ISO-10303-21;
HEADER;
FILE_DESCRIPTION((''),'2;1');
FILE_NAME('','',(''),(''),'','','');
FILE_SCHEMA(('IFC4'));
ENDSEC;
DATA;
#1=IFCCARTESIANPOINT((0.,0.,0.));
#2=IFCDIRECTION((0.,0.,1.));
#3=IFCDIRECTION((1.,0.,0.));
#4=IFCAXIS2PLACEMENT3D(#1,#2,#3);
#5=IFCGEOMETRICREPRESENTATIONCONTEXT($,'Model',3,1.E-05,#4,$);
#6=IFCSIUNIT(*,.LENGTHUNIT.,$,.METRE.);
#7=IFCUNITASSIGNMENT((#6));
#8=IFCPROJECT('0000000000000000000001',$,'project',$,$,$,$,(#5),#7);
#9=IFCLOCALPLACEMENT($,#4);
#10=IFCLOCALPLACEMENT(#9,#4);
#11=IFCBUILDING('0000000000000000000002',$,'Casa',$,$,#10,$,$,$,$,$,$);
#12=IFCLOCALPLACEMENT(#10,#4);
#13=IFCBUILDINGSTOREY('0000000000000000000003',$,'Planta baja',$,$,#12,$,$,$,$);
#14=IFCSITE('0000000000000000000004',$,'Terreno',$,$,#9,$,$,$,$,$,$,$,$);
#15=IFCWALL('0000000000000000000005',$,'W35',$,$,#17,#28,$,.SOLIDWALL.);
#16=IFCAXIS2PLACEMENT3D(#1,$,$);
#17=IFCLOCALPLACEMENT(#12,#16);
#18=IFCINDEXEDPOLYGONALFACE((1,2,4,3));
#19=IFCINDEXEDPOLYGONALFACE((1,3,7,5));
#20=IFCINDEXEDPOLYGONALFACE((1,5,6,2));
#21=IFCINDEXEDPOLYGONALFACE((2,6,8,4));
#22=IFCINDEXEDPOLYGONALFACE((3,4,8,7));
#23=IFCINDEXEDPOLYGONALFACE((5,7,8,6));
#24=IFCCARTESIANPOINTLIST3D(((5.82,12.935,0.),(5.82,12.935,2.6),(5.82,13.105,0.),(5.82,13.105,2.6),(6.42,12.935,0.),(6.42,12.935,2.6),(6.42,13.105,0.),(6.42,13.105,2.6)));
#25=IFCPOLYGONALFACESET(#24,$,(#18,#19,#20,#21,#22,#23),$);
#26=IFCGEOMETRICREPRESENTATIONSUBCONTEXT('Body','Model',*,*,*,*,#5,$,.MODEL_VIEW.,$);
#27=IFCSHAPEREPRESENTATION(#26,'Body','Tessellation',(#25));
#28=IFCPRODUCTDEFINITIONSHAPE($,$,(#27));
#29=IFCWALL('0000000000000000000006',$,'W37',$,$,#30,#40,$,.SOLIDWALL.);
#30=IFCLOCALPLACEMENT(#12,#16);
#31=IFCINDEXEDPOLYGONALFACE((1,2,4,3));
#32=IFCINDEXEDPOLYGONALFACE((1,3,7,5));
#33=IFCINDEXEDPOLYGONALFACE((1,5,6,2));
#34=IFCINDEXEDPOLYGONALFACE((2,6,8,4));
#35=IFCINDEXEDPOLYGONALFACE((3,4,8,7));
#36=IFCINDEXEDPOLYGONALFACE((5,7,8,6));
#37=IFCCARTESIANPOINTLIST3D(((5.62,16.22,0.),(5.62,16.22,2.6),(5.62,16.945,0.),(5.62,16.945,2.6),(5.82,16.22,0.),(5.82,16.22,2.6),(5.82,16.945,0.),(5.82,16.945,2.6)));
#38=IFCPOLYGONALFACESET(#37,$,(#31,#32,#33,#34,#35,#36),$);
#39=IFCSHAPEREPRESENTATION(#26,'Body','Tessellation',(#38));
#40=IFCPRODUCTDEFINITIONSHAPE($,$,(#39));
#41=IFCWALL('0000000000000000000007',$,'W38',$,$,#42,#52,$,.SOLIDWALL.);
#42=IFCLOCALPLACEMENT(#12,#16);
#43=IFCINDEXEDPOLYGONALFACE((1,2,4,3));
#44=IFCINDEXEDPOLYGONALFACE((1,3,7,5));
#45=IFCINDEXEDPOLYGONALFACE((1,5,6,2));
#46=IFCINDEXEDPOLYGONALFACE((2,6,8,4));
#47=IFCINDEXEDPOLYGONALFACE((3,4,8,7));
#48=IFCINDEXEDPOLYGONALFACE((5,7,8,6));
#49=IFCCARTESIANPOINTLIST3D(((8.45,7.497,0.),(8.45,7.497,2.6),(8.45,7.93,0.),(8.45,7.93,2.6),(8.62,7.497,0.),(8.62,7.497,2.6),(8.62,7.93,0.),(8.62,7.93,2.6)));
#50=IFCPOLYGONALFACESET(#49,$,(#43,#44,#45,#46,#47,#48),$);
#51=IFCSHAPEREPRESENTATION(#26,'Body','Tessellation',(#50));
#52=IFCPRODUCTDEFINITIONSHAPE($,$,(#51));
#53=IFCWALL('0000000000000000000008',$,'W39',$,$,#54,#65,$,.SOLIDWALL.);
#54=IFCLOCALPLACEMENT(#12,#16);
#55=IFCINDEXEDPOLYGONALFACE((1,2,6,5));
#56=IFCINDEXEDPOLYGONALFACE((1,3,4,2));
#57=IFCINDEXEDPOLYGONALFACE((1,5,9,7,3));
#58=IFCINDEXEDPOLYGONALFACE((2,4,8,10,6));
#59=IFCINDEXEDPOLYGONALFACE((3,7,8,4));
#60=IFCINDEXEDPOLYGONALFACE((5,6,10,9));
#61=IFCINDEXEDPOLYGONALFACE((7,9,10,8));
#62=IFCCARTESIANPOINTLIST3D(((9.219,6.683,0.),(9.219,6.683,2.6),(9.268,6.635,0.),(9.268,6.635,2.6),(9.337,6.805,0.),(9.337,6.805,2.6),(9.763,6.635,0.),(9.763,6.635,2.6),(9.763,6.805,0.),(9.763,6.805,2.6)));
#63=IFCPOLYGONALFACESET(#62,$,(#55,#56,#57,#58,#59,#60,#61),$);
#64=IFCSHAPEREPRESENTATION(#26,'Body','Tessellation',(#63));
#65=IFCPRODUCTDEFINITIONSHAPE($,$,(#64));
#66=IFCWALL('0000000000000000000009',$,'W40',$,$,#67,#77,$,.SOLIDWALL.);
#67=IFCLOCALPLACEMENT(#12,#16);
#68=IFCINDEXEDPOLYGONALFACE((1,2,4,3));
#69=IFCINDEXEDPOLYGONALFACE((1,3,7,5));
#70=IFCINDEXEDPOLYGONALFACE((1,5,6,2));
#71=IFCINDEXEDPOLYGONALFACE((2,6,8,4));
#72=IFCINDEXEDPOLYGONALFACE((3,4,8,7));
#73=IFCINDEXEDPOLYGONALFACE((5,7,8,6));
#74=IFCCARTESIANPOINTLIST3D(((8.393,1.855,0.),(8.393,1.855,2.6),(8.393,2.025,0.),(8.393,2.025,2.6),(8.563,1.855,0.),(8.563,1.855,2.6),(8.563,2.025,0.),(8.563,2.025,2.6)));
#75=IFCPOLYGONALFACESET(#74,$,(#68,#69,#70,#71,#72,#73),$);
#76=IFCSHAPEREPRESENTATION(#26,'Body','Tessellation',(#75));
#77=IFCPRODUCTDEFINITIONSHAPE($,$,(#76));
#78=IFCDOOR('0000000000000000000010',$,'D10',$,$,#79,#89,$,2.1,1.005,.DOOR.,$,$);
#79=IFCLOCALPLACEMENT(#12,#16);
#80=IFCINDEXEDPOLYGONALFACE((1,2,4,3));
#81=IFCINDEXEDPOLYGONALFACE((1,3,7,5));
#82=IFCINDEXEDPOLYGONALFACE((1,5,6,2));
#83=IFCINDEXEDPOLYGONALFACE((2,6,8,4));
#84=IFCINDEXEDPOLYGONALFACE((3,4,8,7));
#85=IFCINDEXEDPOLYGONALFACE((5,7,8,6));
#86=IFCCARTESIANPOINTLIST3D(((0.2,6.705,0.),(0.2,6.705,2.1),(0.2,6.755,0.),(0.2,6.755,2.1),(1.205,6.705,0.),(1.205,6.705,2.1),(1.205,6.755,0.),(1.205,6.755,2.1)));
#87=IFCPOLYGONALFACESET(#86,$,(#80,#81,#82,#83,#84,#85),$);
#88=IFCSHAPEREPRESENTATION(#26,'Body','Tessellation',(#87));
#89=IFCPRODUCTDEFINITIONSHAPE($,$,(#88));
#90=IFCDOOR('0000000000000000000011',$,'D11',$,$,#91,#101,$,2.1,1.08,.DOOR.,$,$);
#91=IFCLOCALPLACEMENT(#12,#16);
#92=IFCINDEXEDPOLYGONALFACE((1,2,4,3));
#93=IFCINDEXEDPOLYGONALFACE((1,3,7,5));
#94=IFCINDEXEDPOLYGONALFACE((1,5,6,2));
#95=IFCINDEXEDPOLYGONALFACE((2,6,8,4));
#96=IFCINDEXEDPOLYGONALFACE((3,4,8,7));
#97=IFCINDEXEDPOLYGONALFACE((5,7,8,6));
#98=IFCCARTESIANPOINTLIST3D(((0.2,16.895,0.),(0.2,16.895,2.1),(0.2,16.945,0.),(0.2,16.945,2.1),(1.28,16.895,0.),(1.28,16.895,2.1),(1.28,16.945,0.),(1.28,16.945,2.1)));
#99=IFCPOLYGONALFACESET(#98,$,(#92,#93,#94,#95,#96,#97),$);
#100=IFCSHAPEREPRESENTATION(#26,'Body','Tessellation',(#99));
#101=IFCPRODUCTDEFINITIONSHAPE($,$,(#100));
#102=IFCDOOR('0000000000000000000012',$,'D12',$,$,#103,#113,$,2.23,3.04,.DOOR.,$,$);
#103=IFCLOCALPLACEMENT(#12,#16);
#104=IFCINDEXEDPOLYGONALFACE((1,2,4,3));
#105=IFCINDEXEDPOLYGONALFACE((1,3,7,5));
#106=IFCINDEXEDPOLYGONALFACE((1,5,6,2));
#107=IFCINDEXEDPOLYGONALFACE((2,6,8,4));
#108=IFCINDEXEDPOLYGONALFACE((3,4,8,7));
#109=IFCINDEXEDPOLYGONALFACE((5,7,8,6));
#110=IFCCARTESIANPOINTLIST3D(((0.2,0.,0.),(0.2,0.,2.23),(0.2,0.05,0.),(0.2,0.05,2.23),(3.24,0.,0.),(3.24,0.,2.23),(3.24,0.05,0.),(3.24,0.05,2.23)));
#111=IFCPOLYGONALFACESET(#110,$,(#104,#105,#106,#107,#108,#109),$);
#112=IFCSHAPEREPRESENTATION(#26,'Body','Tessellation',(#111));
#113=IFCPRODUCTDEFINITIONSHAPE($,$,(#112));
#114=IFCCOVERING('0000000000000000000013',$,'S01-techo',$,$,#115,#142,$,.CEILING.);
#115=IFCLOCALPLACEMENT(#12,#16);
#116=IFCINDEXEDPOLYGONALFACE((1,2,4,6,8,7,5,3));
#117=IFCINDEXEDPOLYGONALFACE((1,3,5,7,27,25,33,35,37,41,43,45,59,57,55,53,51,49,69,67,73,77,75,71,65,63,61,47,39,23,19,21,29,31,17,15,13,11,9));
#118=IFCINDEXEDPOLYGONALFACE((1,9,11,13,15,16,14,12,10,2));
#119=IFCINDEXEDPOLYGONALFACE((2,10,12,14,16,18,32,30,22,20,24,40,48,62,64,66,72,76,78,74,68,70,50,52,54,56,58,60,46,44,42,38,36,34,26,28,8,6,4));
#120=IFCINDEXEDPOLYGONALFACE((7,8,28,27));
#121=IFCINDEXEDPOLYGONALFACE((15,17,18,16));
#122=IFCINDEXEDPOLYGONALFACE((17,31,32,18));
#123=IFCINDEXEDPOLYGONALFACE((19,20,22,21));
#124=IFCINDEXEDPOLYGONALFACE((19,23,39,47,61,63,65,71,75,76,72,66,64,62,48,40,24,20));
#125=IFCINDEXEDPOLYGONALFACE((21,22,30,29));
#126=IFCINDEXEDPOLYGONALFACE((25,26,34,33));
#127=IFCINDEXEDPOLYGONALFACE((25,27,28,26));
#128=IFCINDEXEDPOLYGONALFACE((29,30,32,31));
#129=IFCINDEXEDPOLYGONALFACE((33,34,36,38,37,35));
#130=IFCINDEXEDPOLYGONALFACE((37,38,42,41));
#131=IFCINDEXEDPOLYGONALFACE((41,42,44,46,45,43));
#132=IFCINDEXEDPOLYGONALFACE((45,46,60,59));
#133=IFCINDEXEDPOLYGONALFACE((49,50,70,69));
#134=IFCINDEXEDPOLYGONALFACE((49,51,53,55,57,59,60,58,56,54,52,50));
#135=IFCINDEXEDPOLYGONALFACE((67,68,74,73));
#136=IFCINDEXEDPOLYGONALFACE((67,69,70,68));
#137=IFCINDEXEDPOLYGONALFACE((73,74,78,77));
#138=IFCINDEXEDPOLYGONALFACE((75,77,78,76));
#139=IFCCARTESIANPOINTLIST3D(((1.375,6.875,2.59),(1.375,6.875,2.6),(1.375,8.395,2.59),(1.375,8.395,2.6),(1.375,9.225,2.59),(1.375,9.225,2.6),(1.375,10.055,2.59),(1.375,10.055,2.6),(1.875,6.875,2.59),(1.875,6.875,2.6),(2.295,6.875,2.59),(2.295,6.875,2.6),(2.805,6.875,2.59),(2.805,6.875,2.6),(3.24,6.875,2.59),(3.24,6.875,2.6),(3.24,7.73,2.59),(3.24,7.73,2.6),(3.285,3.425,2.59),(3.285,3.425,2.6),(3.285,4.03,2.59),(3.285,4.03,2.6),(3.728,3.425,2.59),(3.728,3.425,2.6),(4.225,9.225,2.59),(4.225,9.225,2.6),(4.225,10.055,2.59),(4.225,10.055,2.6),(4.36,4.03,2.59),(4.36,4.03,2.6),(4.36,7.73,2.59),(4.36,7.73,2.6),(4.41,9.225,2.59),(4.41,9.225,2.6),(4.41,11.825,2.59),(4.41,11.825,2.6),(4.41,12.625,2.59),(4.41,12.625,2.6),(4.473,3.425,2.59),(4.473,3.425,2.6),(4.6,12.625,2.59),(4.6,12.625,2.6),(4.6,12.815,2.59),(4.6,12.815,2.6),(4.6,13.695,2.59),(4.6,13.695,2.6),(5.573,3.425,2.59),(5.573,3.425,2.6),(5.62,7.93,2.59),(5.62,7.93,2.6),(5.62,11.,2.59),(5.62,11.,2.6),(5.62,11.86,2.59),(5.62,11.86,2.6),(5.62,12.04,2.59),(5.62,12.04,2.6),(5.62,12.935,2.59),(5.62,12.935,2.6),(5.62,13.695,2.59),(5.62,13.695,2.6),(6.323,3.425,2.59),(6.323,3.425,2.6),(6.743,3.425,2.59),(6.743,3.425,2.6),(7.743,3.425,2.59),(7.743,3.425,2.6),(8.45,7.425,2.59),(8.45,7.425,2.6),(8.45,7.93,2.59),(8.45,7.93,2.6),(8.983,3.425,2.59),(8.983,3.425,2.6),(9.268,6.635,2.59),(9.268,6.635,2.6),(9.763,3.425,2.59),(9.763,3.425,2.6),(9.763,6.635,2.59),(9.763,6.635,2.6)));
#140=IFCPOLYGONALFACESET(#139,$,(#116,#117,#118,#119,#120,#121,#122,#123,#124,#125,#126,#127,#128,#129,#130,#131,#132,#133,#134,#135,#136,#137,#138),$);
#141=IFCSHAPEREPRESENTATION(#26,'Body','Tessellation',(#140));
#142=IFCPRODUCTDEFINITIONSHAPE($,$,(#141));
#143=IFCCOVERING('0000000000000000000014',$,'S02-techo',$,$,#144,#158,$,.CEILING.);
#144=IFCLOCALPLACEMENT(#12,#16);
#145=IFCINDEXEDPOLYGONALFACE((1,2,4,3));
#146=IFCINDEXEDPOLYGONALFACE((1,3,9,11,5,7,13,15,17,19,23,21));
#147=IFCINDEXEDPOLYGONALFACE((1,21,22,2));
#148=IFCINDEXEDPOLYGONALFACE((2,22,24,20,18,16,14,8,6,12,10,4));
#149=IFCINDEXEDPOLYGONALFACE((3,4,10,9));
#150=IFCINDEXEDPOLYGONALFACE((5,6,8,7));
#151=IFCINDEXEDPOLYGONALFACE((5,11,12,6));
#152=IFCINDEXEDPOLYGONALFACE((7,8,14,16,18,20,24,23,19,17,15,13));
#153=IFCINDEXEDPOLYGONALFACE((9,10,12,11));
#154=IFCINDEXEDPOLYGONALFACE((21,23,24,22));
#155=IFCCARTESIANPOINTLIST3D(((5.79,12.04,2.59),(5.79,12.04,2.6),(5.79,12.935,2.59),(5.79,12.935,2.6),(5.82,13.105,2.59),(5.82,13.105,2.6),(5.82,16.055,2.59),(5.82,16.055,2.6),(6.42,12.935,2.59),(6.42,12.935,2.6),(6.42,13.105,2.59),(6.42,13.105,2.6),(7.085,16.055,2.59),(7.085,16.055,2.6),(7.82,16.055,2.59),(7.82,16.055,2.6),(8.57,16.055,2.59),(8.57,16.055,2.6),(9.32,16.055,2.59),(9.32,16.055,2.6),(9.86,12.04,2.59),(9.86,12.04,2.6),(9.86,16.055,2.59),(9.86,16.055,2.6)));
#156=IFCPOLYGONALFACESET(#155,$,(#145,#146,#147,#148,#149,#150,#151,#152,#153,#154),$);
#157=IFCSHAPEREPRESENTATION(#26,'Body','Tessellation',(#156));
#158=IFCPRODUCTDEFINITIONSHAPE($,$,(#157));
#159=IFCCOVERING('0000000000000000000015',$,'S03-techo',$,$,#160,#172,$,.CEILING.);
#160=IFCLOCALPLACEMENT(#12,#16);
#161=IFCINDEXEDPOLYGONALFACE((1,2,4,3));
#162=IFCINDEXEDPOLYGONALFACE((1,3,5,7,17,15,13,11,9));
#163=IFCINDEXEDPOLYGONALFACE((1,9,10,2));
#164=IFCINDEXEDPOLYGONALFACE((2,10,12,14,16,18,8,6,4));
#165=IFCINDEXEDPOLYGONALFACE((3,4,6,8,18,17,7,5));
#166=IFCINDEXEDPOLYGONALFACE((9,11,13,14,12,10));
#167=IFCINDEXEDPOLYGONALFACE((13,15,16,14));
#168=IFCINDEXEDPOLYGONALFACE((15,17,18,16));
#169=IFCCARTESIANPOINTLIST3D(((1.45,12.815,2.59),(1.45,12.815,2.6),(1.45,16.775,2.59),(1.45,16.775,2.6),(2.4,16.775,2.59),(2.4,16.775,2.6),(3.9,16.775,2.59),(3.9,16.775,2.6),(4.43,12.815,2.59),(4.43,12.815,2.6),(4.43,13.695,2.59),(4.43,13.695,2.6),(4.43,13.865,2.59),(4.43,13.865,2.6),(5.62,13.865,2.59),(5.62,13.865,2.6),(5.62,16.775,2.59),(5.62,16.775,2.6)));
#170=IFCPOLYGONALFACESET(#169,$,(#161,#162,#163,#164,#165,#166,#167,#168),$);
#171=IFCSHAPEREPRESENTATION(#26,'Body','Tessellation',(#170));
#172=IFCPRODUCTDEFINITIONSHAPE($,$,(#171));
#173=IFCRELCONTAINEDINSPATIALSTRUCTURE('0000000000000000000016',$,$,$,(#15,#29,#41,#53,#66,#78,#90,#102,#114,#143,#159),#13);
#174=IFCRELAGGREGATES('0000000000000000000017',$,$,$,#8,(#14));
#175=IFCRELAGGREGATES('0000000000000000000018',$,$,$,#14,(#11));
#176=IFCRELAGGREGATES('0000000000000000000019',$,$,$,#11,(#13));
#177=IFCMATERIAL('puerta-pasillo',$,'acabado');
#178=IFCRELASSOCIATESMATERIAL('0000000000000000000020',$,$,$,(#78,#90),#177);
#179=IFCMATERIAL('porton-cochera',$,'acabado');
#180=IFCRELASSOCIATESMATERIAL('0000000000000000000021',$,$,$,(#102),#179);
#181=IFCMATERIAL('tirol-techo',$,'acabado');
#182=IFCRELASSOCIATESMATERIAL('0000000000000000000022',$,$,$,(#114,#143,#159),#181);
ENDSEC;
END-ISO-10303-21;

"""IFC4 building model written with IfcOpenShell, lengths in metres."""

from ifc_helpers import new_model, si_unit, frame, origin_with_axes, place, context, subcontext, project, spatial, line, indexed_curve, outline, extrude, material, element, save


model = new_model("IFC4")

# Units and contexts
model_context = context("Model", 3, precision=1e-05, world=origin_with_axes())
body_context = subcontext(model_context, "Body", "Model", "MODEL_VIEW")
ifc_project = project(units=[si_unit("LENGTHUNIT", "METRE")], contexts=[model_context])

# Site, building, storey
site_placement = place(None, origin_with_axes())
site = spatial("IfcSite", under=ifc_project, at=site_placement, Name="Terreno")
building_placement = place(site_placement, origin_with_axes())
building = spatial("IfcBuilding", under=site, at=building_placement, Name="Casa")
storey_placement = place(building_placement, origin_with_axes())
storey = spatial("IfcBuildingStorey", under=building, at=storey_placement, Name="Planta baja")

# Walls
wall_1_placement = place(storey_placement, origin_with_axes())
element("IfcWall", 1, at=wall_1_placement, inside=storey, Name="W35", PredefinedType="SOLIDWALL", context=body_context, shape_type="SweptSolid", body=[
    extrude(outline(indexed_curve([(6.42, 13.105), (6.42, 12.935), (5.82, 12.935), (5.82, 13.105)], segments=[line(1, 2, 3, 4, 1)])), origin_with_axes(), (0.0, 0.0, 1.0), 2.6),
])
wall_2_placement = place(storey_placement, origin_with_axes())
element("IfcWall", 2, at=wall_2_placement, inside=storey, Name="W37", PredefinedType="SOLIDWALL", context=body_context, shape_type="SweptSolid", body=[
    extrude(outline(indexed_curve([(5.62, 16.945), (5.82, 16.945), (5.82, 16.22), (5.62, 16.22)], segments=[line(1, 2, 3, 4, 1)])), origin_with_axes(), (0.0, 0.0, 1.0), 2.6),
])
wall_3_placement = place(storey_placement, origin_with_axes())
element("IfcWall", 3, at=wall_3_placement, inside=storey, Name="W38", PredefinedType="SOLIDWALL", context=body_context, shape_type="SweptSolid", body=[
    extrude(outline(indexed_curve([(8.62, 7.93), (8.62, 7.497), (8.45, 7.497), (8.45, 7.93)], segments=[line(1, 2, 3, 4, 1)])), origin_with_axes(), (0.0, 0.0, 1.0), 2.6),
])
wall_4_placement = place(storey_placement, origin_with_axes())
element("IfcWall", 4, at=wall_4_placement, inside=storey, Name="W39", PredefinedType="SOLIDWALL", context=body_context, shape_type="SweptSolid", body=[
    extrude(outline(indexed_curve([(9.337, 6.805), (9.763, 6.805), (9.763, 6.635), (9.268, 6.635), (9.219, 6.683)], segments=[line(1, 2, 3, 4, 5, 1)])), origin_with_axes(), (0.0, 0.0, 1.0), 2.6),
])
wall_5_placement = place(storey_placement, origin_with_axes())
element("IfcWall", 5, at=wall_5_placement, inside=storey, Name="W40", PredefinedType="SOLIDWALL", context=body_context, shape_type="SweptSolid", body=[
    extrude(outline(indexed_curve([(8.563, 1.855), (8.393, 1.855), (8.393, 2.025), (8.563, 2.025)], segments=[line(1, 2, 3, 4, 1)])), origin_with_axes(), (0.0, 0.0, 1.0), 2.6),
])

# Doors
ifc_material_1 = material(Name="puerta-pasillo", Category="acabado")
door_1_placement = place(storey_placement, origin_with_axes())
element("IfcDoor", 6, at=door_1_placement, inside=storey, material=ifc_material_1, Name="D10", OverallHeight=2.1, OverallWidth=1.005, PredefinedType="DOOR", context=body_context, shape_type="SweptSolid", body=[
    extrude(outline(indexed_curve([(0.2, 6.705), (1.205, 6.705), (1.205, 6.755), (0.2, 6.755)], segments=[line(1, 2, 3, 4, 1)])), origin_with_axes(), (0.0, 0.0, 1.0), 2.1),
])
door_2_placement = place(storey_placement, origin_with_axes())
element("IfcDoor", 7, at=door_2_placement, inside=storey, material=ifc_material_1, Name="D11", OverallHeight=2.1, OverallWidth=1.08, PredefinedType="DOOR", context=body_context, shape_type="SweptSolid", body=[
    extrude(outline(indexed_curve([(0.2, 16.895), (1.28, 16.895), (1.28, 16.945), (0.2, 16.945)], segments=[line(1, 2, 3, 4, 1)])), origin_with_axes(), (0.0, 0.0, 1.0), 2.1),
])
ifc_material_2 = material(Name="porton-cochera", Category="acabado")
door_3_placement = place(storey_placement, origin_with_axes())
element("IfcDoor", 8, at=door_3_placement, inside=storey, material=ifc_material_2, Name="D12", OverallHeight=2.23, OverallWidth=3.04, PredefinedType="DOOR", context=body_context, shape_type="SweptSolid", body=[
    extrude(outline(indexed_curve([(0.2, 0.0), (3.24, 0.0), (3.24, 0.05), (0.2, 0.05)], segments=[line(1, 2, 3, 4, 1)])), origin_with_axes(), (0.0, 0.0, 1.0), 2.23),
])

# Coverings
ifc_material_3 = material(Name="tirol-techo", Category="acabado")
covering_1_placement = place(storey_placement, origin_with_axes())
element("IfcCovering", 9, at=covering_1_placement, inside=storey, material=ifc_material_3, Name="S01-techo", PredefinedType="CEILING", context=body_context, shape_type="SweptSolid", body=[
    extrude(outline(indexed_curve([(4.6, 12.815), (4.6, 13.695), (5.62, 13.695), (5.62, 12.935), (5.62, 12.04), (5.62, 11.86), (5.62, 11.0), (5.62, 7.93), (8.45, 7.93), (8.45, 7.425), (9.268, 6.635), (9.763, 6.635), (9.763, 3.425), (8.983, 3.425), (7.743, 3.425), (6.743, 3.425), (6.323, 3.425), (5.573, 3.425), (4.473, 3.425), (3.728, 3.425), (3.285, 3.425), (3.285, 4.03), (4.36, 4.03), (4.36, 7.73), (3.24, 7.73), (3.24, 6.875), (2.805, 6.875), (2.295, 6.875), (1.875, 6.875), (1.375, 6.875), (1.375, 8.395), (1.375, 9.225), (1.375, 10.055), (4.225, 10.055), (4.225, 9.225), (4.41, 9.225), (4.41, 11.825), (4.41, 12.625), (4.6, 12.625)], segments=[line(1, 2, 3, 4, 5, 6, 7, 8, 9, 10, 11, 12, 13, 14, 15, 16, 17, 18, 19, 20, 21, 22, 23, 24, 25, 26, 27, 28, 29, 30, 31, 32, 33, 34, 35, 36, 37, 38, 39, 1)])), frame((0.0, 0.0, 2.59), z_axis=(0.0, 0.0, 1.0), x_axis=(1.0, 0.0, 0.0)), (0.0, 0.0, 1.0), 0.01),
])
covering_2_placement = place(storey_placement, origin_with_axes())
element("IfcCovering", 10, at=covering_2_placement, inside=storey, material=ifc_material_3, Name="S02-techo", PredefinedType="CEILING", context=body_context, shape_type="SweptSolid", body=[
    extrude(outline(indexed_curve([(5.79, 12.935), (6.42, 12.935), (6.42, 13.105), (5.82, 13.105), (5.82, 16.055), (7.085, 16.055), (7.82, 16.055), (8.57, 16.055), (9.32, 16.055), (9.86, 16.055), (9.86, 12.04), (5.79, 12.04)], segments=[line(1, 2, 3, 4, 5, 6, 7, 8, 9, 10, 11, 12, 1)])), frame((0.0, 0.0, 2.59), z_axis=(0.0, 0.0, 1.0), x_axis=(1.0, 0.0, 0.0)), (0.0, 0.0, 1.0), 0.01),
])
covering_3_placement = place(storey_placement, origin_with_axes())
element("IfcCovering", 11, at=covering_3_placement, inside=storey, material=ifc_material_3, Name="S03-techo", PredefinedType="CEILING", context=body_context, shape_type="SweptSolid", body=[
    extrude(outline(indexed_curve([(1.45, 16.775), (2.4, 16.775), (3.9, 16.775), (5.62, 16.775), (5.62, 13.865), (4.43, 13.865), (4.43, 13.695), (4.43, 12.815), (1.45, 12.815)], segments=[line(1, 2, 3, 4, 5, 6, 7, 8, 9, 1)])), frame((0.0, 0.0, 2.59), z_axis=(0.0, 0.0, 1.0), x_axis=(1.0, 0.0, 0.0)), (0.0, 0.0, 1.0), 0.01),
])

save(model, "model.ifc")
